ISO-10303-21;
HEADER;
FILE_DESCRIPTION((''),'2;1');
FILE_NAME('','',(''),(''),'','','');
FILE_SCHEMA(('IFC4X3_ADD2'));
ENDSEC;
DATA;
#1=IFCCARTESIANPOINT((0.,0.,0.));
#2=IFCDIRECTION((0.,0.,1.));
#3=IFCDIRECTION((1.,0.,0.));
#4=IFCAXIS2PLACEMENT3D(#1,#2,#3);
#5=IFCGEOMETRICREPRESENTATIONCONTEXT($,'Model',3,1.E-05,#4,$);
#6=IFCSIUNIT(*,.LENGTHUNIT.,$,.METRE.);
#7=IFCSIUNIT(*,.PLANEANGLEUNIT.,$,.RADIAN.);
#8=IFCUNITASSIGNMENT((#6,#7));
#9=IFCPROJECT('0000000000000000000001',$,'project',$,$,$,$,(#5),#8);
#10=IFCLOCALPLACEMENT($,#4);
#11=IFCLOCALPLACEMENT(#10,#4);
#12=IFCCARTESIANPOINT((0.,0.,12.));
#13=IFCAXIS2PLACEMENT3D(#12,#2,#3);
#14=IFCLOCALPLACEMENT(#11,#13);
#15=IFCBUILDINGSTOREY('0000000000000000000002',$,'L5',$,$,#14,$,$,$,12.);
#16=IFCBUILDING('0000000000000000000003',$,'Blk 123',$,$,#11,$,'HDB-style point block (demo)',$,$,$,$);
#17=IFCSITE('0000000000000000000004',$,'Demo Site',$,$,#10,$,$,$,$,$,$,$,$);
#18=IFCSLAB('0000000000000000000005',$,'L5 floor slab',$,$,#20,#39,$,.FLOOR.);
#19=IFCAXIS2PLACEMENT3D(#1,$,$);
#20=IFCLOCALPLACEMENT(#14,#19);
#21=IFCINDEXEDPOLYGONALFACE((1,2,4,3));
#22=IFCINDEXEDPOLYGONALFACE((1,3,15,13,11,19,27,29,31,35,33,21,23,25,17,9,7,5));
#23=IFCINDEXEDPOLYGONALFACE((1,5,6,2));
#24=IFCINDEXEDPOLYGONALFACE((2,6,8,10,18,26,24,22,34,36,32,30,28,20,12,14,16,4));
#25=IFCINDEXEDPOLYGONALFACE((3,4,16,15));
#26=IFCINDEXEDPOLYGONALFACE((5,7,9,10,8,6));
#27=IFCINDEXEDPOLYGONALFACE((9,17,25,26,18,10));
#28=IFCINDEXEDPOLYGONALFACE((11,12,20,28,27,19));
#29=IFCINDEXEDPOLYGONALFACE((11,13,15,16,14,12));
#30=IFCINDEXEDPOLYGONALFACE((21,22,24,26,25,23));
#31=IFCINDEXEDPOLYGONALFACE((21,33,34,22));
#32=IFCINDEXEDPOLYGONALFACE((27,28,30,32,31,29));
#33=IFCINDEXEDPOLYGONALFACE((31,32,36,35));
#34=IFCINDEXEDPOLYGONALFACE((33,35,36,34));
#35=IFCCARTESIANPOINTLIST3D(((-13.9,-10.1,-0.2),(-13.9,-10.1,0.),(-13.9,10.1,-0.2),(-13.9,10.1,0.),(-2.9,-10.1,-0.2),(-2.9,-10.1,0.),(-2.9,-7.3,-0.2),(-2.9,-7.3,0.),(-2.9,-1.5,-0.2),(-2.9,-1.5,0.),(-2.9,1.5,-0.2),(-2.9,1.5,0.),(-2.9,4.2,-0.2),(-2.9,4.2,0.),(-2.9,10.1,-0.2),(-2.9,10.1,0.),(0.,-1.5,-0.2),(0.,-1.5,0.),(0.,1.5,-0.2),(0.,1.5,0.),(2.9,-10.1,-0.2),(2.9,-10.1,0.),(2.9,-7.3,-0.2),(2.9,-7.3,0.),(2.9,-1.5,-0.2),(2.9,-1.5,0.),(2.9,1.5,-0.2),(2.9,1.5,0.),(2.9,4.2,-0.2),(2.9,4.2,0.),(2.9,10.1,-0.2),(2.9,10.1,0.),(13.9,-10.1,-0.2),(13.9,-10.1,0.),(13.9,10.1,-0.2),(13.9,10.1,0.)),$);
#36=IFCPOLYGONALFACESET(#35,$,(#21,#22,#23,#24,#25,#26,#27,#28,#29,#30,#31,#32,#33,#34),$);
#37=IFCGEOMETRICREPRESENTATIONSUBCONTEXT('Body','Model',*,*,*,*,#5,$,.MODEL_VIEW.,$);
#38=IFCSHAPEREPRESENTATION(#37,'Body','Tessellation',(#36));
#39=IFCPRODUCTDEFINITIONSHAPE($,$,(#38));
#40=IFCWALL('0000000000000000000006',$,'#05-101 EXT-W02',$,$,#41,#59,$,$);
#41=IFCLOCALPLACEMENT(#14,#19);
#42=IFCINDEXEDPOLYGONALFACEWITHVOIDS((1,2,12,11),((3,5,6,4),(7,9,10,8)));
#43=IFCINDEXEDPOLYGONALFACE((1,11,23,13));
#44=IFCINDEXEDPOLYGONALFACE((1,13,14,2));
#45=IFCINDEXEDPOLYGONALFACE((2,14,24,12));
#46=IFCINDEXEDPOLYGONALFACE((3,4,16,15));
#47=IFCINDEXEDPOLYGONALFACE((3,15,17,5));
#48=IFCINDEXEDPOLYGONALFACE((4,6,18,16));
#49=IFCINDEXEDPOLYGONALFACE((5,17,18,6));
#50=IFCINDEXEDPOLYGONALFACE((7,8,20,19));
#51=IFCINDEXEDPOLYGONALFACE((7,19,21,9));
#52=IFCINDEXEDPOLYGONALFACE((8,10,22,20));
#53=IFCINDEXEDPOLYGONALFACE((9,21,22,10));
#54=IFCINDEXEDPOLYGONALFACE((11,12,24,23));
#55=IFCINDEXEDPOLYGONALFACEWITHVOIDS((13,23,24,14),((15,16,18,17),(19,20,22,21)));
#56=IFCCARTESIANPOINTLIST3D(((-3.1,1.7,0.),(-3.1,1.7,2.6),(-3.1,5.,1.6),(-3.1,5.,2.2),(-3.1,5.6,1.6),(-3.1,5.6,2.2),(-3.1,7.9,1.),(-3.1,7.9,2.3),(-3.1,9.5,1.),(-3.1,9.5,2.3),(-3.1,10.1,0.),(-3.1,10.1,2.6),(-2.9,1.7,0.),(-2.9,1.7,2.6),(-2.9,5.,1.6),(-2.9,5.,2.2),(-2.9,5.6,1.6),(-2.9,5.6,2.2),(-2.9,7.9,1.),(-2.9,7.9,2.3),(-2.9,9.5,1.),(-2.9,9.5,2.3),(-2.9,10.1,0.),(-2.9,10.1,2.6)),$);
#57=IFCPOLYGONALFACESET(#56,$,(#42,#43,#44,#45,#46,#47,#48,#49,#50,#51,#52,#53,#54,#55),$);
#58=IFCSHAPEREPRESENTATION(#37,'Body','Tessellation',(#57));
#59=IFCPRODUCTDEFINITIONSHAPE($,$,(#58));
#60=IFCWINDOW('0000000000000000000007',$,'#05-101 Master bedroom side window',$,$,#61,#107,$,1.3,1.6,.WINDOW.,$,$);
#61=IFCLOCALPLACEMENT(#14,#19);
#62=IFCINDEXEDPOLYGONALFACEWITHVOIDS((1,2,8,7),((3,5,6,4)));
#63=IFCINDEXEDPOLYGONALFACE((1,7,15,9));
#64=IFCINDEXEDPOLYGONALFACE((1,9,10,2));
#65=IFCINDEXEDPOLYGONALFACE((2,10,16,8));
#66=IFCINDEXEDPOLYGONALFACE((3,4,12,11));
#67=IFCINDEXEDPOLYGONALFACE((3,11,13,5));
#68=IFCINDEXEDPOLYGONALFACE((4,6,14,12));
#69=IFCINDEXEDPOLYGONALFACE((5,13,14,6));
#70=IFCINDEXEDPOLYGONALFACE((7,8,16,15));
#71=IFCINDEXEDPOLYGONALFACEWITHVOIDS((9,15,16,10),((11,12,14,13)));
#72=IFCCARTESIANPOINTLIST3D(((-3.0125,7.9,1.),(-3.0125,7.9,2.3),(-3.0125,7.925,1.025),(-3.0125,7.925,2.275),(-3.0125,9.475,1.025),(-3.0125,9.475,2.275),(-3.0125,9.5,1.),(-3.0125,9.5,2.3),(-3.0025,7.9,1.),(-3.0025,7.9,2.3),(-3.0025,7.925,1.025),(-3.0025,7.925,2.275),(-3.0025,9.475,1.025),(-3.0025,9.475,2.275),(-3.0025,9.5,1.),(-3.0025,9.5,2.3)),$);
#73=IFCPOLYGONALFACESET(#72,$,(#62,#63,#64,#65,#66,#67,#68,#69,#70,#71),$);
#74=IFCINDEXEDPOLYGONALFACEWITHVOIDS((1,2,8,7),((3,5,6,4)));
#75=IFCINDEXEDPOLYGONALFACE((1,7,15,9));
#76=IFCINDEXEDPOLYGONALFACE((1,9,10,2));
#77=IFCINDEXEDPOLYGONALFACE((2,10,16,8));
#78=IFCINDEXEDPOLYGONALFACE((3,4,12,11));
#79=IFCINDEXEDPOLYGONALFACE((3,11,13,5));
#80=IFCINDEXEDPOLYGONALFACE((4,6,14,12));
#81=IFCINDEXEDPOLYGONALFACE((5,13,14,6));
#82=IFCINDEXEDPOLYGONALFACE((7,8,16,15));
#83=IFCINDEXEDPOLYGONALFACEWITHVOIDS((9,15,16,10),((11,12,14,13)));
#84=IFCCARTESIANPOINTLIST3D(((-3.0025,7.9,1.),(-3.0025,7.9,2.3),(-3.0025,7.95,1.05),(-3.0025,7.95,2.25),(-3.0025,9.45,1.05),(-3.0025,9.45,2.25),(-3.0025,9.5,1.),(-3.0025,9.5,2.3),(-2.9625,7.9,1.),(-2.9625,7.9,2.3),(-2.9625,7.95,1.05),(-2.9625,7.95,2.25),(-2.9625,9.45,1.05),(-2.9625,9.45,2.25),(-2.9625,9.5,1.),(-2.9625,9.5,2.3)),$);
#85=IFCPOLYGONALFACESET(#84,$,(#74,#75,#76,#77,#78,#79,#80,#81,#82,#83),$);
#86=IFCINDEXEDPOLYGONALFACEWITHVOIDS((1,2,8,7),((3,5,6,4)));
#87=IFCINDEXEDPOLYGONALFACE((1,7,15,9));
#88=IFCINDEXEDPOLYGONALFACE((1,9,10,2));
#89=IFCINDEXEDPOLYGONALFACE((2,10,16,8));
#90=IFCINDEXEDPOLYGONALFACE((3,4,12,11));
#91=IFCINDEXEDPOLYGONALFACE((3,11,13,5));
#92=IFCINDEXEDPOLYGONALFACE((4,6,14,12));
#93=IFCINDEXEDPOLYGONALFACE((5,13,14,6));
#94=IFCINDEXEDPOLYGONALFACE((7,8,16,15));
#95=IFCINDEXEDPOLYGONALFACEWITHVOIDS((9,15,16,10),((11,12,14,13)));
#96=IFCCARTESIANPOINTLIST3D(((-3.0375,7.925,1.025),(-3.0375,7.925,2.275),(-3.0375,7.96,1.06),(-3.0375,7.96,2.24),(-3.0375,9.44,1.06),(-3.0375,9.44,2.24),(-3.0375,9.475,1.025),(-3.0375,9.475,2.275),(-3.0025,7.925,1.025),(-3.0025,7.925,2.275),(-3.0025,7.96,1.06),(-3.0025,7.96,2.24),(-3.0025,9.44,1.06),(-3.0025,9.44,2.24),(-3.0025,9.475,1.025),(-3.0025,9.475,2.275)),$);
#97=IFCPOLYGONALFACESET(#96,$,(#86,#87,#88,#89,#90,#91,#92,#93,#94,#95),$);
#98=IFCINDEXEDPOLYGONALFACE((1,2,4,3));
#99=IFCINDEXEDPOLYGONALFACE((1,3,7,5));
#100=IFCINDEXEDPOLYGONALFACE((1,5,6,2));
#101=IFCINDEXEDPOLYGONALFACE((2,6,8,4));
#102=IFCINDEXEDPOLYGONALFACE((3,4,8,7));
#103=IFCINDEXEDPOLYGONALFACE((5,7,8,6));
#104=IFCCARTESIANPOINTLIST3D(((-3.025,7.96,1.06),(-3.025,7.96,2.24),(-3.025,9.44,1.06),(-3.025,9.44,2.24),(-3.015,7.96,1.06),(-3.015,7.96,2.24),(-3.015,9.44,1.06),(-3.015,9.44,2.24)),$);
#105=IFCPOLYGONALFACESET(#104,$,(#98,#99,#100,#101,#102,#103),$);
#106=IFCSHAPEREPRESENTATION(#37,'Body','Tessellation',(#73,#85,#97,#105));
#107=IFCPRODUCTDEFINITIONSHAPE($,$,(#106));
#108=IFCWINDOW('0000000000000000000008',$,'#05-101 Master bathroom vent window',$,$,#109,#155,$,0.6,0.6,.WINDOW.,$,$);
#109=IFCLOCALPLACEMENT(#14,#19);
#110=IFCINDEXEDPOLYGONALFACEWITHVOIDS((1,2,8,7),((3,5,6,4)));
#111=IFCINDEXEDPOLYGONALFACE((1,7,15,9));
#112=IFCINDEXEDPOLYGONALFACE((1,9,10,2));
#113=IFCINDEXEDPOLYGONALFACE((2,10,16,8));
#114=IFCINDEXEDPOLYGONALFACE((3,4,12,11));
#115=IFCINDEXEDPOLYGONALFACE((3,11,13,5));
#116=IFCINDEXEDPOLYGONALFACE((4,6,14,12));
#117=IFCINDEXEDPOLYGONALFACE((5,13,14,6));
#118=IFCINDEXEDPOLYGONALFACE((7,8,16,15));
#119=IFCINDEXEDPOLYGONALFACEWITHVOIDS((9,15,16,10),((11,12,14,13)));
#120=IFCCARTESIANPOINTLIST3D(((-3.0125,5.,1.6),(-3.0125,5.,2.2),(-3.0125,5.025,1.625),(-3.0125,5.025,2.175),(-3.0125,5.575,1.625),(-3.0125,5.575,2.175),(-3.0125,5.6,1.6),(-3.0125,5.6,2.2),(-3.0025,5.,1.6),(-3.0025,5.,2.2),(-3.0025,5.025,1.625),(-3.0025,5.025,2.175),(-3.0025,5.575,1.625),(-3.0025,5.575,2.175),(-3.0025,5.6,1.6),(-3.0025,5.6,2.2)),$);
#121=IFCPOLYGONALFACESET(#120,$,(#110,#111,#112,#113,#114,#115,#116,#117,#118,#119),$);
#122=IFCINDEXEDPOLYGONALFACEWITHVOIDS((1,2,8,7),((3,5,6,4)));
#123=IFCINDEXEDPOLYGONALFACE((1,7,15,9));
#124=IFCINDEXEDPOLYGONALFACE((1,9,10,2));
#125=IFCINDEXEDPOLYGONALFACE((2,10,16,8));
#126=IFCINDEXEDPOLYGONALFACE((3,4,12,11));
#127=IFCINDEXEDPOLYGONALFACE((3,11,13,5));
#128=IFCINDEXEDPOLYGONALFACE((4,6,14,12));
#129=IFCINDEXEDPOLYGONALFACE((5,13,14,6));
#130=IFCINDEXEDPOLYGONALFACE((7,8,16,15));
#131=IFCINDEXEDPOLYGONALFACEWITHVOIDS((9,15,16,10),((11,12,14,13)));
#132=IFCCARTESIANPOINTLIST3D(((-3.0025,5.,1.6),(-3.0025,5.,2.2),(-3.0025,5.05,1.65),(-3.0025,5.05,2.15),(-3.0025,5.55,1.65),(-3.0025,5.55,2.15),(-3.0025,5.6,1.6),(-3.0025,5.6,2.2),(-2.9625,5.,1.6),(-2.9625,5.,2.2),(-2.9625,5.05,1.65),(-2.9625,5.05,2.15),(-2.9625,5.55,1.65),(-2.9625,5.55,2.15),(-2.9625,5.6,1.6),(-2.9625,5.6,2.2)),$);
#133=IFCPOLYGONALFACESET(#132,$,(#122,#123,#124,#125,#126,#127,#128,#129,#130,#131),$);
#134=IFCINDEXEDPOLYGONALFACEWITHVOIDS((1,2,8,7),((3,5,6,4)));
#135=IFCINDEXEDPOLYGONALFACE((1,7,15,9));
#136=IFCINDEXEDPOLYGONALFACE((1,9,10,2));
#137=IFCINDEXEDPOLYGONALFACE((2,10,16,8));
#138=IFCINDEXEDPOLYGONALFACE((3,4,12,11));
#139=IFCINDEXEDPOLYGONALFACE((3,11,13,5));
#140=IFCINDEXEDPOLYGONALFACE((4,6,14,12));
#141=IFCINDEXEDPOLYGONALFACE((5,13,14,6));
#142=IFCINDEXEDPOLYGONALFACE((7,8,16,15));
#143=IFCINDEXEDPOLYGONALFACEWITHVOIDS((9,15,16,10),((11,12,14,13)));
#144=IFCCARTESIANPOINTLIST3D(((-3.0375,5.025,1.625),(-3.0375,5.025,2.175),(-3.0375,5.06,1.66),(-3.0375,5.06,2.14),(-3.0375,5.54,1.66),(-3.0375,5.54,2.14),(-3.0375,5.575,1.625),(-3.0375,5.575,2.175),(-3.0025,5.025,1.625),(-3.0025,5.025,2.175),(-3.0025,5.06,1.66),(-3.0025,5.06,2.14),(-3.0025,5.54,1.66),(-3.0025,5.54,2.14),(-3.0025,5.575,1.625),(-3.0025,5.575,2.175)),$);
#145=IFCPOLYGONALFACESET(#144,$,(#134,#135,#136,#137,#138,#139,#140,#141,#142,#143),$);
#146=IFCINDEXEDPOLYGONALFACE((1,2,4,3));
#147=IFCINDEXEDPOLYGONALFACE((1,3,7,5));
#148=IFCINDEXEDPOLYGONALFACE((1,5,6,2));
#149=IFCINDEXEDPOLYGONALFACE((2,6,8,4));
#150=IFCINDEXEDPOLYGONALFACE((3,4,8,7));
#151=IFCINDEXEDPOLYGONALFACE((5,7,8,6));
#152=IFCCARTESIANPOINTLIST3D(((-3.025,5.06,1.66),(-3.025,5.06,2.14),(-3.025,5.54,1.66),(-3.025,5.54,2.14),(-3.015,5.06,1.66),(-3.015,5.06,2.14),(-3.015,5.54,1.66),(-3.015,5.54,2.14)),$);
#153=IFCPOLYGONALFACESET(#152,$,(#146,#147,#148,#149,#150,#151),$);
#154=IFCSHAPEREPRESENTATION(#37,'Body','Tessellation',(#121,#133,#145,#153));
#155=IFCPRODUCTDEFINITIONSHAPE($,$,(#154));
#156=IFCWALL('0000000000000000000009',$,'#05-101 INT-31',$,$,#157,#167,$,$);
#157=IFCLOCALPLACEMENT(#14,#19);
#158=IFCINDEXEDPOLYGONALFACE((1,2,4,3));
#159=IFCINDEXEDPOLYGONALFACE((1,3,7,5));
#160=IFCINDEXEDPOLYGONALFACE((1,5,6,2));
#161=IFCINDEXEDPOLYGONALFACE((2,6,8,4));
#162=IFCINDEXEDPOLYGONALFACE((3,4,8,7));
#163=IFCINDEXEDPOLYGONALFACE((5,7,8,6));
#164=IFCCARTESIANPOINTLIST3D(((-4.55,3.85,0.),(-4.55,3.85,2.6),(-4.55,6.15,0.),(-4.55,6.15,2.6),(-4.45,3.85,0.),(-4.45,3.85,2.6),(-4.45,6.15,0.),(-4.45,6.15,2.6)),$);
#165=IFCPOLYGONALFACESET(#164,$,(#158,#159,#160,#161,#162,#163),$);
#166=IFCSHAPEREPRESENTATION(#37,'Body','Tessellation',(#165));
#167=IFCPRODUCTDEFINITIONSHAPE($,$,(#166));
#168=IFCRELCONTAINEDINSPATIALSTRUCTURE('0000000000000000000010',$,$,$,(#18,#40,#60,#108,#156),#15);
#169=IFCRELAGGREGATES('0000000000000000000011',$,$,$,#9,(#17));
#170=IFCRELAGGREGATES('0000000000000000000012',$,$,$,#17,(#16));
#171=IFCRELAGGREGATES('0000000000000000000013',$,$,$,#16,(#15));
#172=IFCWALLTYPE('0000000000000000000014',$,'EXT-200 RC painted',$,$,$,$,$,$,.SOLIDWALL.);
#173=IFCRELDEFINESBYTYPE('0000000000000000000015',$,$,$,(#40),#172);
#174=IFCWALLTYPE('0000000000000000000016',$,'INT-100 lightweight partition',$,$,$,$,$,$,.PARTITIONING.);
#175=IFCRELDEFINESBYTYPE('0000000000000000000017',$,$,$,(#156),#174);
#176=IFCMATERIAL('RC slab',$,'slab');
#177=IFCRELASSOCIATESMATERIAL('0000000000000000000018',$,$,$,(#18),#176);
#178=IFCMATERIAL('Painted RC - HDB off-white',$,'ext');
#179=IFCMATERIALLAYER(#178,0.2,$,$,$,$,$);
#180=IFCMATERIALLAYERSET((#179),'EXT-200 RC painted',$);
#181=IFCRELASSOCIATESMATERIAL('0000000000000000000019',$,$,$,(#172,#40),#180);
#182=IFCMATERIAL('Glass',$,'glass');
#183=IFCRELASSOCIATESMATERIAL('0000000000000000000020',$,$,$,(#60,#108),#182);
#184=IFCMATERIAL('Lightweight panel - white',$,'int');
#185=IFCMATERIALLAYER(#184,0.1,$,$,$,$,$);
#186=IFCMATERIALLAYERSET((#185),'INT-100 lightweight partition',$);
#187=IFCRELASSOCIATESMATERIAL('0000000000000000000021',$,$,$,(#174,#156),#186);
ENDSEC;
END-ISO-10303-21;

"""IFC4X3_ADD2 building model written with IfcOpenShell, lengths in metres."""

from ifc_helpers import new_model, si_unit, frame, origin, origin_with_axes, place, context, subcontext, project, spatial, polyline, line, indexed_curve, outline, extrude, material, layer, layer_set, layer_usage, type_object, element, fill, save


model = new_model("IFC4X3_ADD2")

# Units and contexts
model_context = context("Model", 3, precision=1e-05, world=origin_with_axes())
body_context = subcontext(model_context, "Body", "Model", "MODEL_VIEW")
ifc_project = project(units=[si_unit("LENGTHUNIT", "METRE"), si_unit("PLANEANGLEUNIT", "RADIAN")], contexts=[model_context])

# Site, building, storey
site_placement = place(None, origin_with_axes())
site = spatial("IfcSite", under=ifc_project, at=site_placement, Name="Demo Site")
building_placement = place(site_placement, origin_with_axes())
building = spatial("IfcBuilding", under=site, at=building_placement, Name="Blk 123", LongName="HDB-style point block (demo)")
storey_placement = place(building_placement, frame((0.0, 0.0, 12.0), z_axis=(0.0, 0.0, 1.0), x_axis=(1.0, 0.0, 0.0)))
storey = spatial("IfcBuildingStorey", under=building, at=storey_placement, Name="L5", Elevation=12.0)

# Slab
ifc_material_1 = material(Name="RC slab", Category="slab")
slab_placement = place(storey_placement, frame((0.0, 0.0, -0.2), z_axis=(0.0, 0.0, 1.0), x_axis=(1.0, 0.0, 0.0)))
element("IfcSlab", 1, at=slab_placement, inside=storey, material=ifc_material_1, Name="L5 floor slab", PredefinedType="FLOOR", context=body_context, shape_type="SweptSolid", body=[
    extrude(outline(polyline([(2.9, -10.1), (13.9, -10.1), (13.9, 10.1), (2.9, 10.1), (2.9, 4.2), (2.9, 1.5), (0.0, 1.5), (-2.9, 1.5), (-2.9, 4.2), (-2.9, 10.1), (-13.9, 10.1), (-13.9, -10.1), (-2.9, -10.1), (-2.9, -7.3), (-2.9, -1.5), (0.0, -1.5), (2.9, -1.5), (2.9, -7.3), (2.9, -10.1)])), origin(), (0.0, 0.0, 1.0), 0.2),
])

# Wall, openings, windows
ifc_material_2 = material(Name="Painted RC - HDB off-white", Category="ext")
ifc_layer_1 = layer(ifc_material_2, 0.2)
ifc_layer_set_1 = layer_set([ifc_layer_1], Name="EXT-200 RC painted")
ifc_layer_usage_1 = layer_usage(ifc_layer_set_1, "AXIS2", "POSITIVE", 0.0)
wall_type_1 = type_object("IfcWallType", Name="EXT-200 RC painted", PredefinedType="SOLIDWALL", material=ifc_layer_set_1)
wall_1_placement = place(storey_placement, frame((-2.9, 1.7, 0.0), z_axis=(0.0, 0.0, 1.0), x_axis=(0.0, 1.0, 0.0)))
wall_1 = element("IfcWall", 2, at=wall_1_placement, inside=storey, type_object=wall_type_1, material=ifc_layer_usage_1, Name="#05-101 EXT-W02", context=body_context, shape_type="SweptSolid", body=[
    extrude(outline(indexed_curve([(0.0, 0.0), (0.0, 0.2), (8.4, 0.2), (8.4, 0.0), (0.0, 0.0)], self_intersect=False)), origin_with_axes(), (0.0, 0.0, 1.0), 2.6),
])
opening_1_placement = place(wall_1_placement, frame((6.2, -0.1, 1.0), z_axis=(0.0, 0.0, 1.0), x_axis=(1.0, 0.0, 0.0)))
opening_1 = element("IfcOpeningElement", 3, at=opening_1_placement, cuts=wall_1, context=body_context, shape_type="SweptSolid", body=[
    extrude(outline(indexed_curve([(0.0, 0.0), (0.0, 0.4), (1.6, 0.4), (1.6, 0.0), (0.0, 0.0)], self_intersect=False)), origin_with_axes(), (0.0, 0.0, 1.0), 1.3),
])
opening_2_placement = place(wall_1_placement, frame((3.3, -0.1, 1.6), z_axis=(0.0, 0.0, 1.0), x_axis=(1.0, 0.0, 0.0)))
opening_2 = element("IfcOpeningElement", 4, at=opening_2_placement, cuts=wall_1, context=body_context, shape_type="SweptSolid", body=[
    extrude(outline(indexed_curve([(0.0, 0.0), (0.0, 0.4), (0.6, 0.4), (0.6, 0.0), (0.0, 0.0)], self_intersect=False)), origin_with_axes(), (0.0, 0.0, 1.0), 0.6),
])
ifc_material_3 = material(Name="Glass", Category="glass")
window_1_placement = place(opening_1_placement, frame((0.0, 0.1125, 0.0), z_axis=(0.0, 0.0, 1.0), x_axis=(1.0, 0.0, 0.0)))
window_1 = element("IfcWindow", 5, at=window_1_placement, inside=storey, material=ifc_material_3, Name="#05-101 Master bedroom side window", OverallHeight=1.3, OverallWidth=1.6, PredefinedType="WINDOW", context=body_context, shape_type="SweptSolid", body=[
    extrude(outline(indexed_curve([(0.0, 0.0), (1.6, 0.0), (1.6, 1.3), (0.0, 1.3)], segments=[line(1, 2, 3, 4, 1)]), holes=[indexed_curve([(0.025, 0.025), (1.575, 0.025), (1.575, 1.275), (0.025, 1.275)], segments=[line(1, 2, 3, 4, 1)])]), frame((0.0, 0.09, 0.0), z_axis=(0.0, -1.0, 0.0), x_axis=(1.0, 0.0, 0.0)), (0.0, 0.0, -1.0), 0.01),
    extrude(outline(indexed_curve([(0.0, 0.0), (1.6, 0.0), (1.6, 1.3), (0.0, 1.3)], segments=[line(1, 2, 3, 4, 1)]), holes=[indexed_curve([(0.05, 0.05), (1.55, 0.05), (1.55, 1.25), (0.05, 1.25)], segments=[line(1, 2, 3, 4, 1)])]), frame((0.0, 0.05, 0.0), z_axis=(0.0, -1.0, 0.0), x_axis=(1.0, 0.0, 0.0)), (0.0, 0.0, -1.0), 0.04),
    extrude(outline(indexed_curve([(0.0, 0.0), (1.55, 0.0), (1.55, 1.25), (0.0, 1.25)], segments=[line(1, 2, 3, 4, 1)]), holes=[indexed_curve([(0.035, 0.035), (1.515, 0.035), (1.515, 1.215), (0.035, 1.215)], segments=[line(1, 2, 3, 4, 1)])]), frame((0.025, 0.09, 0.025), z_axis=(0.0, -1.0, 0.0), x_axis=(1.0, 0.0, 0.0)), (0.0, 0.0, -1.0), 0.035),
    extrude(outline(indexed_curve([(0.035, 0.035), (1.515, 0.035), (1.515, 1.215), (0.035, 1.215)], segments=[line(1, 2, 3, 4, 1)])), frame((0.025, 0.1025, 0.025), z_axis=(0.0, -1.0, 0.0), x_axis=(1.0, 0.0, 0.0)), (0.0, 0.0, -1.0), 0.01),
])
fill(opening_1, window_1)
window_2_placement = place(opening_2_placement, frame((0.0, 0.1125, 0.0), z_axis=(0.0, 0.0, 1.0), x_axis=(1.0, 0.0, 0.0)))
window_2 = element("IfcWindow", 6, at=window_2_placement, inside=storey, material=ifc_material_3, Name="#05-101 Master bathroom vent window", OverallHeight=0.6, OverallWidth=0.6, PredefinedType="WINDOW", context=body_context, shape_type="SweptSolid", body=[
    extrude(outline(indexed_curve([(0.0, 0.0), (0.6, 0.0), (0.6, 0.6), (0.0, 0.6)], segments=[line(1, 2, 3, 4, 1)]), holes=[indexed_curve([(0.025, 0.025), (0.575, 0.025), (0.575, 0.575), (0.025, 0.575)], segments=[line(1, 2, 3, 4, 1)])]), frame((0.0, 0.09, 0.0), z_axis=(0.0, -1.0, 0.0), x_axis=(1.0, 0.0, 0.0)), (0.0, 0.0, -1.0), 0.01),
    extrude(outline(indexed_curve([(0.0, 0.0), (0.6, 0.0), (0.6, 0.6), (0.0, 0.6)], segments=[line(1, 2, 3, 4, 1)]), holes=[indexed_curve([(0.05, 0.05), (0.55, 0.05), (0.55, 0.55), (0.05, 0.55)], segments=[line(1, 2, 3, 4, 1)])]), frame((0.0, 0.05, 0.0), z_axis=(0.0, -1.0, 0.0), x_axis=(1.0, 0.0, 0.0)), (0.0, 0.0, -1.0), 0.04),
    extrude(outline(indexed_curve([(0.0, 0.0), (0.55, 0.0), (0.55, 0.55), (0.0, 0.55)], segments=[line(1, 2, 3, 4, 1)]), holes=[indexed_curve([(0.035, 0.035), (0.515, 0.035), (0.515, 0.515), (0.035, 0.515)], segments=[line(1, 2, 3, 4, 1)])]), frame((0.025, 0.09, 0.025), z_axis=(0.0, -1.0, 0.0), x_axis=(1.0, 0.0, 0.0)), (0.0, 0.0, -1.0), 0.035),
    extrude(outline(indexed_curve([(0.035, 0.035), (0.515, 0.035), (0.515, 0.515), (0.035, 0.515)], segments=[line(1, 2, 3, 4, 1)])), frame((0.025, 0.1025, 0.025), z_axis=(0.0, -1.0, 0.0), x_axis=(1.0, 0.0, 0.0)), (0.0, 0.0, -1.0), 0.01),
])
fill(opening_2, window_2)

# Wall
ifc_material_4 = material(Name="Lightweight panel - white", Category="int")
ifc_layer_2 = layer(ifc_material_4, 0.1)
ifc_layer_set_2 = layer_set([ifc_layer_2], Name="INT-100 lightweight partition")
ifc_layer_usage_2 = layer_usage(ifc_layer_set_2, "AXIS2", "POSITIVE", -0.05)
wall_type_2 = type_object("IfcWallType", Name="INT-100 lightweight partition", PredefinedType="PARTITIONING", material=ifc_layer_set_2)
wall_2_placement = place(storey_placement, frame((-4.5, 3.85, 0.0), z_axis=(0.0, 0.0, 1.0), x_axis=(0.0, 1.0, 0.0)))
element("IfcWall", 7, at=wall_2_placement, inside=storey, type_object=wall_type_2, material=ifc_layer_usage_2, Name="#05-101 INT-31", context=body_context, shape_type="SweptSolid", body=[
    extrude(outline(indexed_curve([(0.0, 0.0), (0.0, 0.1), (2.3, 0.1), (2.3, 0.0), (0.0, 0.0)], self_intersect=False)), frame((0.0, -0.05, 0.0), z_axis=(0.0, 0.0, 1.0), x_axis=(1.0, 0.0, 0.0)), (0.0, 0.0, 1.0), 2.6),
])

save(model, "model.ifc")
